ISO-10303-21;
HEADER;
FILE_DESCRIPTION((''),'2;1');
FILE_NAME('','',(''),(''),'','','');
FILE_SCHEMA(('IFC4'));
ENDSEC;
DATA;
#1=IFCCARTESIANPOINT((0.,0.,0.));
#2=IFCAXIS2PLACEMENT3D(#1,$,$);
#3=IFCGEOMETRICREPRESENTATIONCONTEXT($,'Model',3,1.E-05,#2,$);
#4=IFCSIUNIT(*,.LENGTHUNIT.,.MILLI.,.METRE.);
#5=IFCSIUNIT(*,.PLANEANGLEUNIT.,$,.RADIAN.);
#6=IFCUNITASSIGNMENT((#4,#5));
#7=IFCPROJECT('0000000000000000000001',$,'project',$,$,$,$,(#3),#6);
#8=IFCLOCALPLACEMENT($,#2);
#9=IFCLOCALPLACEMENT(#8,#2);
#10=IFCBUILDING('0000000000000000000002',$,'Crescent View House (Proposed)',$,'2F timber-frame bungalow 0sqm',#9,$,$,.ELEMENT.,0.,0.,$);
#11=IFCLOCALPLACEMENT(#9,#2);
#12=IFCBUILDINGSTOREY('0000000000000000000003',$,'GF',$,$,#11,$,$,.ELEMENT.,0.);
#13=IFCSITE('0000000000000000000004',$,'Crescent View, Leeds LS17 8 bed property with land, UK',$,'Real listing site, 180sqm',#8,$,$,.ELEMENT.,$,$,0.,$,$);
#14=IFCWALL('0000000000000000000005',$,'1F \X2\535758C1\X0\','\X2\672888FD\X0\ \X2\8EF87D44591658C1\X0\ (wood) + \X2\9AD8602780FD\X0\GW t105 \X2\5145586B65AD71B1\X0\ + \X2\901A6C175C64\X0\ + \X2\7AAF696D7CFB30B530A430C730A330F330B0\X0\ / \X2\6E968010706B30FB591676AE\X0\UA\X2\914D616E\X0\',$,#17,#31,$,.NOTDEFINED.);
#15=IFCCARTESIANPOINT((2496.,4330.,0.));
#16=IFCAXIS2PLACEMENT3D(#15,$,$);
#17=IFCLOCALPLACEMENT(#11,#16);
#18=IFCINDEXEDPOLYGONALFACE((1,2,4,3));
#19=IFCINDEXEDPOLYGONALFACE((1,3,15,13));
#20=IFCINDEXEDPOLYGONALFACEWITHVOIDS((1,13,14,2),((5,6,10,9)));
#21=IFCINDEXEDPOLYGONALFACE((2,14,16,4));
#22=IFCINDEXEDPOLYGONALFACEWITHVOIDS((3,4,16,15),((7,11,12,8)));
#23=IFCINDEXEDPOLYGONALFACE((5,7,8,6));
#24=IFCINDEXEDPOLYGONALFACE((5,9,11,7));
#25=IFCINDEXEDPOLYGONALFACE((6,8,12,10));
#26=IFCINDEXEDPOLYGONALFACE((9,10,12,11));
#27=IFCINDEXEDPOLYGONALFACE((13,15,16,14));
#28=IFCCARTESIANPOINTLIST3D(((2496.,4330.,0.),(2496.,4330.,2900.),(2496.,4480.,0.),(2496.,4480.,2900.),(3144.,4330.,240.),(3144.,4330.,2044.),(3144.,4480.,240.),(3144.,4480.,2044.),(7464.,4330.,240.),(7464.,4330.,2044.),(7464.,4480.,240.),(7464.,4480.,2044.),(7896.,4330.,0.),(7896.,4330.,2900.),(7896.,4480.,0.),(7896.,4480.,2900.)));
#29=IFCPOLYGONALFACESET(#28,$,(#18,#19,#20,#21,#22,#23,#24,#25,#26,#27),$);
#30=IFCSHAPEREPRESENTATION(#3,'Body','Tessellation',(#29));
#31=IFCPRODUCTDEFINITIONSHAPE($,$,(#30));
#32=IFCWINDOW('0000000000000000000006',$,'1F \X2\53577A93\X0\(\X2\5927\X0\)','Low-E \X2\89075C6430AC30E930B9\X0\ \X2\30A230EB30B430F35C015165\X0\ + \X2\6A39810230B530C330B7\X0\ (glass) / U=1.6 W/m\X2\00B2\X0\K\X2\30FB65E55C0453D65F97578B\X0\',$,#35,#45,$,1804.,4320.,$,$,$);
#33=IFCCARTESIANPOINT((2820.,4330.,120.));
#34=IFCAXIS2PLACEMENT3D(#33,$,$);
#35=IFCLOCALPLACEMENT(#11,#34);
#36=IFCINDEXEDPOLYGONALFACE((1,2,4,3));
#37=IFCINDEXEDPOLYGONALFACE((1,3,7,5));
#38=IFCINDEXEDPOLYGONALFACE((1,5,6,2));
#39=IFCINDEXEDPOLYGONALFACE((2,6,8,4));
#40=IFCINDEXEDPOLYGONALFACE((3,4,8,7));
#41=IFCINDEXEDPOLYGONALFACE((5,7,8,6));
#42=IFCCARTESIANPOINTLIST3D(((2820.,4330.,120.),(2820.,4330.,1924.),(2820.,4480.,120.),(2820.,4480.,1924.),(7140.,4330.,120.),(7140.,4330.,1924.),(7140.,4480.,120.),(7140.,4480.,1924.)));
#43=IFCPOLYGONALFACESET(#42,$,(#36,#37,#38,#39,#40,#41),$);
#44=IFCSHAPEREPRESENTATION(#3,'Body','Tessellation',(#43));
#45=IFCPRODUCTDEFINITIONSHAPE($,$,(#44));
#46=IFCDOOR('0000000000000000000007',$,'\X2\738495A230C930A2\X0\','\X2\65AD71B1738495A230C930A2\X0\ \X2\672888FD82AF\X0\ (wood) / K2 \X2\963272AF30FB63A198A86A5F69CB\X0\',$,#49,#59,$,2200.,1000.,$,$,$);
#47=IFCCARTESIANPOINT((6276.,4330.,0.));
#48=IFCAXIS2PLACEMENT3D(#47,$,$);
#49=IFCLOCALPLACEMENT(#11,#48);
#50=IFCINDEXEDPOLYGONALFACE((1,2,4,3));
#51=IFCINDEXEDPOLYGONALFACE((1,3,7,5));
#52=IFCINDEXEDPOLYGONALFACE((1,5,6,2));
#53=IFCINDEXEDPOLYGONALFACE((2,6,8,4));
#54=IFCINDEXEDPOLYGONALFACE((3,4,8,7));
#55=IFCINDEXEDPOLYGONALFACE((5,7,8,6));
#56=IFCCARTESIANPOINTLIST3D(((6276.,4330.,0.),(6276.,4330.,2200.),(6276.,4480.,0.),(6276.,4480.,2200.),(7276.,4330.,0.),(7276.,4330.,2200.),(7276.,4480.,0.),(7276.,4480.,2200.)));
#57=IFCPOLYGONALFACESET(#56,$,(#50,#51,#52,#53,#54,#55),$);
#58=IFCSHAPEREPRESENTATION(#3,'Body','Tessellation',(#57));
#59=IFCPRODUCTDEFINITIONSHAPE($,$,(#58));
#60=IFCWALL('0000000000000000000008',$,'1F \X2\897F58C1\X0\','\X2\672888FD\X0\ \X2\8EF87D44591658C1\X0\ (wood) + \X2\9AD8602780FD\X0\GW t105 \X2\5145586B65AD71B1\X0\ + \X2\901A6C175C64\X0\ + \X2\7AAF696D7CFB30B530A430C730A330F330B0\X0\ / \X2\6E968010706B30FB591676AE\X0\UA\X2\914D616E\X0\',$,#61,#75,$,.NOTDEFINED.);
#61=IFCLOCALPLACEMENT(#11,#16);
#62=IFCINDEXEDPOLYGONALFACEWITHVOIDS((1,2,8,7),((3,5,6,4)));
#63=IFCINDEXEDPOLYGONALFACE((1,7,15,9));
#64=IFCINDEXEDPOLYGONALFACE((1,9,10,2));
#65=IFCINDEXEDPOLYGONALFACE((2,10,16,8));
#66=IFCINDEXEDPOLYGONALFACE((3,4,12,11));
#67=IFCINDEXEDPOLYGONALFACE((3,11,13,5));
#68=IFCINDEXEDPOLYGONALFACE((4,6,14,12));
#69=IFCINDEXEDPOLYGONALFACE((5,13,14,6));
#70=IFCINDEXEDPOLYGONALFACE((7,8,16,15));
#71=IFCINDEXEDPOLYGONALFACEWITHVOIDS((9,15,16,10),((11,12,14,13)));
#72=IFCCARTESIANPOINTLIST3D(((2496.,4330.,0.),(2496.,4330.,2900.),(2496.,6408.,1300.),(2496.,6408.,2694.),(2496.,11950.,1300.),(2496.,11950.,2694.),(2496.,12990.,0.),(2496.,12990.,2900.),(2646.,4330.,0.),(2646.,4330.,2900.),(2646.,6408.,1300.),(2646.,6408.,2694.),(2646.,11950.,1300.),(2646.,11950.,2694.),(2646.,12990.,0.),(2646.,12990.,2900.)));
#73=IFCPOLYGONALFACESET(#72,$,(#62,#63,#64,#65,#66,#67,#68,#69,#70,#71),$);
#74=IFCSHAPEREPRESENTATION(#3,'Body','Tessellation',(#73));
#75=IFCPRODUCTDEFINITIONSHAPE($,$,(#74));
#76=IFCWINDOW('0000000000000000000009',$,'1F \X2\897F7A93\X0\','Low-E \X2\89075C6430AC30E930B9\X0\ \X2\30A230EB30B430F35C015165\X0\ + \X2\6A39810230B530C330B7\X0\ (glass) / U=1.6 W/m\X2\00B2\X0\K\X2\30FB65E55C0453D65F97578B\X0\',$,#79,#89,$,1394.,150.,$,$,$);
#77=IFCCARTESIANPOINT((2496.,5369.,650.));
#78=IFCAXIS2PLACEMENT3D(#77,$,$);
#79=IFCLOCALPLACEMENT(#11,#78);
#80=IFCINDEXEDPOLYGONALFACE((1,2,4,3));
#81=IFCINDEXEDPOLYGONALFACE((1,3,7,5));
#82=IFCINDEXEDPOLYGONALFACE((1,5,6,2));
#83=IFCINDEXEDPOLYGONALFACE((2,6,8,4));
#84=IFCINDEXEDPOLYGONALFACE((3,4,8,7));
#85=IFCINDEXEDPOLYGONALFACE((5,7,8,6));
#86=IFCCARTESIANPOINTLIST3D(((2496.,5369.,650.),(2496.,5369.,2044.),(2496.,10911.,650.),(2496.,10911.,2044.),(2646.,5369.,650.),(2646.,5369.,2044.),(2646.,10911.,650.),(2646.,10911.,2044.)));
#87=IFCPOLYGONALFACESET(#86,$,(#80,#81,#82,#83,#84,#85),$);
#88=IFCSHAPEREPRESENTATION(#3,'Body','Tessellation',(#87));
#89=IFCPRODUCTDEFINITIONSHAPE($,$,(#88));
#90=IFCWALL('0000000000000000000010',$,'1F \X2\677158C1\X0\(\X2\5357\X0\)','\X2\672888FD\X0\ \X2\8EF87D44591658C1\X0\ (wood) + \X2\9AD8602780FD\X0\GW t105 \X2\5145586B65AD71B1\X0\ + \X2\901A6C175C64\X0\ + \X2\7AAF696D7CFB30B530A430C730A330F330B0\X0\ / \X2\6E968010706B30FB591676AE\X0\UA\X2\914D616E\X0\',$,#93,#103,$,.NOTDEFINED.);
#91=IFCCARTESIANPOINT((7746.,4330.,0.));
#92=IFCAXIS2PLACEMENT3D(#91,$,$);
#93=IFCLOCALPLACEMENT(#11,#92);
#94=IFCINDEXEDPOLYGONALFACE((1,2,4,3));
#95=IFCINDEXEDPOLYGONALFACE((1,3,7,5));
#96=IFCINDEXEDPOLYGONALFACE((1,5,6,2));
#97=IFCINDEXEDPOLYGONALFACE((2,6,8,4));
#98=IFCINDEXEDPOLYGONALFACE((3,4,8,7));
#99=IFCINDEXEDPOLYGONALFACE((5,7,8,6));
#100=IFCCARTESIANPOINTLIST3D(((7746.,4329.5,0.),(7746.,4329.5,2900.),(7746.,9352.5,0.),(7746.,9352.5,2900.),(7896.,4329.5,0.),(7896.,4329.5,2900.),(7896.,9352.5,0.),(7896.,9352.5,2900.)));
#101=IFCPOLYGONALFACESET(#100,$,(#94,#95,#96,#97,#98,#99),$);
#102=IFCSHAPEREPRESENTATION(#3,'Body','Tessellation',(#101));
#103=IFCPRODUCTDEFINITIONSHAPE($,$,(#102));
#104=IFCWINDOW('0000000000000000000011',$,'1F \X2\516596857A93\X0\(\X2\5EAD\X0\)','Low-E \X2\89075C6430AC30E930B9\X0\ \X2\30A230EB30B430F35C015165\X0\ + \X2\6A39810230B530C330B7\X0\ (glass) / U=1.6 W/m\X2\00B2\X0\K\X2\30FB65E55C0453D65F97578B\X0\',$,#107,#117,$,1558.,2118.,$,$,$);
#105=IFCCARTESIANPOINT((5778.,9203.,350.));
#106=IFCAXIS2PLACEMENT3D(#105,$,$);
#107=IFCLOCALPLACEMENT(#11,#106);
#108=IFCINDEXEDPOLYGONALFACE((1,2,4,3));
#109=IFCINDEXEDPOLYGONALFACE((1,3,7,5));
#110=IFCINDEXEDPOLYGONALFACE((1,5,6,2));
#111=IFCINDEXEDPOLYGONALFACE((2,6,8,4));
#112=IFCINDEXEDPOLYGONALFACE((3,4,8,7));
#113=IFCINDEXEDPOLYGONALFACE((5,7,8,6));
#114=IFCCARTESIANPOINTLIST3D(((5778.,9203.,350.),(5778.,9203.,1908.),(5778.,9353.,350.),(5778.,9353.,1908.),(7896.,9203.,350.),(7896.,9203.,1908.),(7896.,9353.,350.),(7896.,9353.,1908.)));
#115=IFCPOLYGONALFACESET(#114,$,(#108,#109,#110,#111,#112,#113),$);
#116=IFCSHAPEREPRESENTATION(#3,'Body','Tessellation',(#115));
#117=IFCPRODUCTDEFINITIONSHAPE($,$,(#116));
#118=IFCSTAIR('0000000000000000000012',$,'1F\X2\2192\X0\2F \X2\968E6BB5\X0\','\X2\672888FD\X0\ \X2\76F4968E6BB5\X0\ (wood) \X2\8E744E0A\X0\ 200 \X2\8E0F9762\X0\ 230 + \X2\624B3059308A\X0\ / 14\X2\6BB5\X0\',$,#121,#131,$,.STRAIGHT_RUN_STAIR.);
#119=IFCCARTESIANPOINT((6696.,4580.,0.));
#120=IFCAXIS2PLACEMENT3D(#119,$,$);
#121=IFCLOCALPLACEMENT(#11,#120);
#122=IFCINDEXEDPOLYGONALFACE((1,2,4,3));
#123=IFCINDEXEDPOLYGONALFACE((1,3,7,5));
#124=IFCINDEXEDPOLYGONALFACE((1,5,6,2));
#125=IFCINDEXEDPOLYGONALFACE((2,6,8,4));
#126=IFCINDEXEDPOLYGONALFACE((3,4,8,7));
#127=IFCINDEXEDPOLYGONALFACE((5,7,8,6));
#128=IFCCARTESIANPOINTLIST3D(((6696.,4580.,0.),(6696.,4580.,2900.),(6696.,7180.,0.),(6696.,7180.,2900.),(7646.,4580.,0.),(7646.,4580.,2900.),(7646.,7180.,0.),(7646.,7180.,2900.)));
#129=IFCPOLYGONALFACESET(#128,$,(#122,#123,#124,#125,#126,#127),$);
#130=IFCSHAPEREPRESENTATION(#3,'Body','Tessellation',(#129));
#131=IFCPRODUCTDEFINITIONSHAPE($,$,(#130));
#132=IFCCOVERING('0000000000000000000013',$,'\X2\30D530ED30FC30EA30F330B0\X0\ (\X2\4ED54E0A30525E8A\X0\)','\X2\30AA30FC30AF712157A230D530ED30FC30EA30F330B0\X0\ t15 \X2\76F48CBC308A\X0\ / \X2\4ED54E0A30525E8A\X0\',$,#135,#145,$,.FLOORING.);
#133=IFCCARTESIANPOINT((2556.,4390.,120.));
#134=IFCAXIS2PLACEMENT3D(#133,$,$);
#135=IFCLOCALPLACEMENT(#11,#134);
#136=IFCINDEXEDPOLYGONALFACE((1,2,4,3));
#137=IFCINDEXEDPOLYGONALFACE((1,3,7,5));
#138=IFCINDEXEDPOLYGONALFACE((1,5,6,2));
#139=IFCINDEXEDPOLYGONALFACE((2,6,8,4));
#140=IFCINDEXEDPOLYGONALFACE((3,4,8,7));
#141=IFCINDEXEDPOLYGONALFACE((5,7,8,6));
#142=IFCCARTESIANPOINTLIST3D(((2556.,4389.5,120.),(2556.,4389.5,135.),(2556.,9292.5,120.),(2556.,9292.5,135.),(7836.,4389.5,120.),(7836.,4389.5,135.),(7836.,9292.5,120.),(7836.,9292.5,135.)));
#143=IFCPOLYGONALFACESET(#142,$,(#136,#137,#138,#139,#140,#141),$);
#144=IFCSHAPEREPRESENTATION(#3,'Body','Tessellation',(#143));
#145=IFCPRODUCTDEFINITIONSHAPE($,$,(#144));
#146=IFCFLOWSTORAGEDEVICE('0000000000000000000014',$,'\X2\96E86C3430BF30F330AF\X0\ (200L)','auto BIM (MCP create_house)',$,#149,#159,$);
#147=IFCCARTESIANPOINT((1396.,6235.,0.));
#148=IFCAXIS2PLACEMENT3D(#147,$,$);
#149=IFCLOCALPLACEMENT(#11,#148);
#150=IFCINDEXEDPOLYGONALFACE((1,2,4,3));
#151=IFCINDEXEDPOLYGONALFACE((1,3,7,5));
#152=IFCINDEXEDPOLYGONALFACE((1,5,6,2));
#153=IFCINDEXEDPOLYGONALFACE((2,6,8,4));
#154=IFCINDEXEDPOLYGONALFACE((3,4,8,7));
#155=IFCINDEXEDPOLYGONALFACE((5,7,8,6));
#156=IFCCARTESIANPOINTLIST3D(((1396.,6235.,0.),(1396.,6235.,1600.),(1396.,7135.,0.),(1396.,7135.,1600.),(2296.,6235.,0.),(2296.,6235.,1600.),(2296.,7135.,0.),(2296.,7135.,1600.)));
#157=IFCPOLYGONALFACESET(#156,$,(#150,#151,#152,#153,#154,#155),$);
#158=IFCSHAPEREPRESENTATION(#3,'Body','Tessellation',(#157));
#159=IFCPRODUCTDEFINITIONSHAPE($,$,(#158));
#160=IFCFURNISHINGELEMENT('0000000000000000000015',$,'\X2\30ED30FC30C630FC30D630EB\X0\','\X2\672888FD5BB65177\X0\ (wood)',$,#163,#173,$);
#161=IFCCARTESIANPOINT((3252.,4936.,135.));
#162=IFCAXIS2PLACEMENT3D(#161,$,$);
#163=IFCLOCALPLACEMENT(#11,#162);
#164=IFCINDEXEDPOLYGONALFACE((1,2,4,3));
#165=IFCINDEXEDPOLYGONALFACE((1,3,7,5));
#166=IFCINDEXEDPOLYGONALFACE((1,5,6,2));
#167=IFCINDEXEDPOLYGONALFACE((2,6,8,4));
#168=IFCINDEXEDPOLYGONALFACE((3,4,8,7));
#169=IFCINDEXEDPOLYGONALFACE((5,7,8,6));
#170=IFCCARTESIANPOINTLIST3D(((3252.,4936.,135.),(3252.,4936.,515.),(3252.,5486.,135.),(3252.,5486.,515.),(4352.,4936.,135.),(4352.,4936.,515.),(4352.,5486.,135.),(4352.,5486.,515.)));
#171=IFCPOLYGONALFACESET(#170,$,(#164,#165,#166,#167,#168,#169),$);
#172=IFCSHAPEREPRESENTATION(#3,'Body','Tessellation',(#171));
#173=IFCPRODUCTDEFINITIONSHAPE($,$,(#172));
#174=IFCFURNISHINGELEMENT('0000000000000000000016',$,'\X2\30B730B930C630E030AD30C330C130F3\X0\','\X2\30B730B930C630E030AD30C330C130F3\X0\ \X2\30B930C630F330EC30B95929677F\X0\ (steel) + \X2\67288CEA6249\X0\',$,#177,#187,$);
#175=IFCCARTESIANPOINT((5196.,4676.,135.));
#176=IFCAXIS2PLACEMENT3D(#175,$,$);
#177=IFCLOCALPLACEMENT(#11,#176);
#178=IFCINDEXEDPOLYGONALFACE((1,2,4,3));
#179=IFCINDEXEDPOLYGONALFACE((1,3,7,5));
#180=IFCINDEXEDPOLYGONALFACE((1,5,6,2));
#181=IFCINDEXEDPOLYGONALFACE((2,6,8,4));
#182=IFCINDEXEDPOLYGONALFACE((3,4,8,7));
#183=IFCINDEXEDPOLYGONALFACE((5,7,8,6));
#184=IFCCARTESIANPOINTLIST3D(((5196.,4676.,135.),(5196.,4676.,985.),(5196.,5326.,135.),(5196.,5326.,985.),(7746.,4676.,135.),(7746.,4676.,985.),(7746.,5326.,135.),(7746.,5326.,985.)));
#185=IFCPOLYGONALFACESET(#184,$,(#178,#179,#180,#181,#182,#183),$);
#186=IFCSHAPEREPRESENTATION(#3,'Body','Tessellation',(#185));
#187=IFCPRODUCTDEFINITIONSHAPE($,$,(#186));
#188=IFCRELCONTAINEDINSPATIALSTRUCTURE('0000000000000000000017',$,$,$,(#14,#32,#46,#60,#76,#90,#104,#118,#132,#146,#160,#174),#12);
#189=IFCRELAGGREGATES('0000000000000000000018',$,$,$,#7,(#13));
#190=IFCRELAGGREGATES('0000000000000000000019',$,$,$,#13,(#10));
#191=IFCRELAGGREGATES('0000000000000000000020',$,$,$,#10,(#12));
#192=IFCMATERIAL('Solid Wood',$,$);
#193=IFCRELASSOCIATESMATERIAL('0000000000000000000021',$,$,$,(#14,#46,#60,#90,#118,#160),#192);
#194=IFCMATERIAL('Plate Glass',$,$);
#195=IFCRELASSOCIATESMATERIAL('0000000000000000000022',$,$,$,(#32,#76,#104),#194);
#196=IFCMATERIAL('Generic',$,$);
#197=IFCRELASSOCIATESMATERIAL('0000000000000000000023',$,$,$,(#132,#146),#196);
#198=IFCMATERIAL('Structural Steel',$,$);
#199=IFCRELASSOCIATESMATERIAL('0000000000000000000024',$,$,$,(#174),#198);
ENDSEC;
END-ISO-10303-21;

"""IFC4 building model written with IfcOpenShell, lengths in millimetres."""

from ifc_helpers import new_model, si_unit, frame, frame_2d, origin, place, context, project, spatial, rectangle, extrude, material, element, fill, save


model = new_model("IFC4")

# Units and contexts
model_context = context("Model", 3, precision=1e-05, world=origin())
ifc_project = project(units=[si_unit("LENGTHUNIT", "METRE", prefix="MILLI"), si_unit("PLANEANGLEUNIT", "RADIAN")], contexts=[model_context])

# Site, building, storey
site_placement = place(None, origin())
site = spatial("IfcSite", under=ifc_project, at=site_placement, Name="Crescent View, Leeds LS17 8 bed property with land, UK", ObjectType="Real listing site, 180sqm", CompositionType="ELEMENT", RefElevation=0.0)
building_placement = place(site_placement, origin())
building = spatial("IfcBuilding", under=site, at=building_placement, Name="Crescent View House (Proposed)", ObjectType="2F timber-frame bungalow 0sqm", CompositionType="ELEMENT", ElevationOfRefHeight=0.0, ElevationOfTerrain=0.0)
storey_placement = place(building_placement, origin())
storey = spatial("IfcBuildingStorey", under=building, at=storey_placement, Name="GF", CompositionType="ELEMENT", Elevation=0.0)

# Shared definitions
ifc_material_1 = material(Name="Solid Wood")

# Wall, openings, window, door
wall_1_placement = place(storey_placement, frame((2496.0, 4330.0, 0.0)))
wall_1 = element("IfcWall", 1, at=wall_1_placement, inside=storey, material=ifc_material_1, Name="1F 南壁", Description="木製 軸組外壁 (wood) + 高性能GW t105 充填断熱 + 通気層 + 窯業系サイディング / 準耐火・外皮UA配慮", PredefinedType="NOTDEFINED", context=model_context, shape_type="SweptSolid", body=[
    extrude(rectangle(XDim=5400.0, YDim=150.0, at=frame_2d((2700.0, 75.0))), frame((2496.0, 4330.0, 0.0)), (0.0, 0.0, 1.0), 2900.0),
])
opening_1_placement = place(storey_placement, frame((2820.0, 4330.0, 120.0)))
opening_1 = element("IfcOpeningElement", 2, at=opening_1_placement, cuts=wall_1, PredefinedType="NOTDEFINED", context=model_context, shape_type="SweptSolid", body=[
    extrude(rectangle(XDim=4320.0, YDim=150.0, at=frame_2d((2160.0, 75.0))), frame((2820.0, 4330.0, 120.0)), (0.0, 0.0, 1.0), 1804.0),
])
opening_2_placement = place(storey_placement, frame((6276.0, 4330.0, 0.0)))
opening_2 = element("IfcOpeningElement", 3, at=opening_2_placement, cuts=wall_1, PredefinedType="NOTDEFINED", context=model_context, shape_type="SweptSolid", body=[
    extrude(rectangle(XDim=1000.0, YDim=150.0, at=frame_2d((500.0, 75.0))), frame((6276.0, 4330.0, 0.0)), (0.0, 0.0, 1.0), 2200.0),
])
ifc_material_2 = material(Name="Plate Glass")
window_1_placement = place(storey_placement, frame((2820.0, 4330.0, 120.0)))
window_1 = element("IfcWindow", 4, at=window_1_placement, inside=storey, material=ifc_material_2, Name="1F 南窓(大)", Description="Low-E 複層ガラス アルゴン封入 + 樹脂サッシ (glass) / U=1.6 W/m²K・日射取得型", OverallHeight=1804.0, OverallWidth=4320.0, context=model_context, shape_type="SweptSolid", body=[
    extrude(rectangle(XDim=4320.0, YDim=150.0, at=frame_2d((2160.0, 75.0))), frame((2820.0, 4330.0, 120.0)), (0.0, 0.0, 1.0), 1804.0),
])
fill(opening_1, window_1)
door_1_placement = place(storey_placement, frame((6276.0, 4330.0, 0.0)))
door_1 = element("IfcDoor", 5, at=door_1_placement, inside=storey, material=ifc_material_1, Name="玄関ドア", Description="断熱玄関ドア 木製芯 (wood) / K2 防犯・採風機構", OverallHeight=2200.0, OverallWidth=1000.0, context=model_context, shape_type="SweptSolid", body=[
    extrude(rectangle(XDim=1000.0, YDim=150.0, at=frame_2d((500.0, 75.0))), frame((6276.0, 4330.0, 0.0)), (0.0, 0.0, 1.0), 2200.0),
])
fill(opening_2, door_1)

# Walls, openings, windows
wall_2_placement = place(storey_placement, frame((2496.0, 4330.0, 0.0)))
wall_2 = element("IfcWall", 6, at=wall_2_placement, inside=storey, material=ifc_material_1, Name="1F 西壁", Description="木製 軸組外壁 (wood) + 高性能GW t105 充填断熱 + 通気層 + 窯業系サイディング / 準耐火・外皮UA配慮", PredefinedType="NOTDEFINED", context=model_context, shape_type="SweptSolid", body=[
    extrude(rectangle(XDim=150.0, YDim=8660.0, at=frame_2d((75.0, 4330.0))), frame((2496.0, 4330.0, 0.0)), (0.0, 0.0, 1.0), 2900.0),
])
opening_3_placement = place(storey_placement, frame((2496.0, 5369.0, 650.0)))
opening_3 = element("IfcOpeningElement", 7, at=opening_3_placement, cuts=wall_2, PredefinedType="NOTDEFINED", context=model_context, shape_type="SweptSolid", body=[
    extrude(rectangle(XDim=150.0, YDim=5542.0, at=frame_2d((75.0, 2771.0))), frame((2496.0, 5369.0, 650.0)), (0.0, 0.0, 1.0), 1394.0),
])
window_2_placement = place(storey_placement, frame((2496.0, 5369.0, 650.0)))
window_2 = element("IfcWindow", 8, at=window_2_placement, inside=storey, material=ifc_material_2, Name="1F 西窓", Description="Low-E 複層ガラス アルゴン封入 + 樹脂サッシ (glass) / U=1.6 W/m²K・日射取得型", OverallHeight=1394.0, OverallWidth=150.0, context=model_context, shape_type="SweptSolid", body=[
    extrude(rectangle(XDim=150.0, YDim=5542.0, at=frame_2d((75.0, 2771.0))), frame((2496.0, 5369.0, 650.0)), (0.0, 0.0, 1.0), 1394.0),
])
fill(opening_3, window_2)
wall_3_placement = place(storey_placement, frame((7746.0, 4330.0, 0.0)))
wall_3 = element("IfcWall", 9, at=wall_3_placement, inside=storey, material=ifc_material_1, Name="1F 東壁(南)", Description="木製 軸組外壁 (wood) + 高性能GW t105 充填断熱 + 通気層 + 窯業系サイディング / 準耐火・外皮UA配慮", PredefinedType="NOTDEFINED", context=model_context, shape_type="SweptSolid", body=[
    extrude(rectangle(XDim=150.0, YDim=5023.0, at=frame_2d((75.0, 2511.0))), frame((7746.0, 4330.0, 0.0)), (0.0, 0.0, 1.0), 2900.0),
])
opening_4_placement = place(storey_placement, frame((5778.0, 9203.0, 350.0)))
opening_4 = element("IfcOpeningElement", 10, at=opening_4_placement, cuts=wall_3, PredefinedType="NOTDEFINED", context=model_context, shape_type="SweptSolid", body=[
    extrude(rectangle(XDim=2118.0, YDim=150.0, at=frame_2d((1059.0, 75.0))), frame((5778.0, 9203.0, 350.0)), (0.0, 0.0, 1.0), 1558.0),
])
window_3_placement = place(storey_placement, frame((5778.0, 9203.0, 350.0)))
window_3 = element("IfcWindow", 11, at=window_3_placement, inside=storey, material=ifc_material_2, Name="1F 入隅窓(庭)", Description="Low-E 複層ガラス アルゴン封入 + 樹脂サッシ (glass) / U=1.6 W/m²K・日射取得型", OverallHeight=1558.0, OverallWidth=2118.0, context=model_context, shape_type="SweptSolid", body=[
    extrude(rectangle(XDim=2118.0, YDim=150.0, at=frame_2d((1059.0, 75.0))), frame((5778.0, 9203.0, 350.0)), (0.0, 0.0, 1.0), 1558.0),
])
fill(opening_4, window_3)

# Stair
stair_placement = place(storey_placement, frame((6696.0, 4580.0, 0.0)))
element("IfcStair", 12, at=stair_placement, inside=storey, material=ifc_material_1, Name="1F→2F 階段", Description="木製 直階段 (wood) 蹴上 200 踏面 230 + 手すり / 14段", PredefinedType="STRAIGHT_RUN_STAIR", context=model_context, shape_type="SweptSolid", body=[
    extrude(rectangle(XDim=950.0, YDim=2600.0, at=frame_2d((475.0, 1300.0))), frame((6696.0, 4580.0, 0.0)), (0.0, 0.0, 1.0), 2900.0),
])

# Covering
ifc_material_3 = material(Name="Generic")
covering_placement = place(storey_placement, frame((2556.0, 4390.0, 120.0)))
element("IfcCovering", 13, at=covering_placement, inside=storey, material=ifc_material_3, Name="フローリング (仕上げ床)", Description="オーク無垢フローリング t15 直貼り / 仕上げ床", PredefinedType="FLOORING", context=model_context, shape_type="SweptSolid", body=[
    extrude(rectangle(XDim=5280.0, YDim=4903.0, at=frame_2d((2640.0, 2451.0))), frame((2556.0, 4390.0, 120.0)), (0.0, 0.0, 1.0), 15.0),
])

# Flow storage device
flow_storage_device_placement = place(storey_placement, frame((1396.0, 6235.0, 0.0)))
element("IfcFlowStorageDevice", 14, at=flow_storage_device_placement, inside=storey, material=ifc_material_3, Name="雨水タンク (200L)", Description="auto BIM (MCP create_house)", context=model_context, shape_type="SweptSolid", body=[
    extrude(rectangle(XDim=900.0, YDim=900.0, at=frame_2d((450.0, 450.0))), frame((1396.0, 6235.0, 0.0)), (0.0, 0.0, 1.0), 1600.0),
])

# Furnishing elements
furnishing_1_placement = place(storey_placement, frame((3252.0, 4936.0, 135.0)))
element("IfcFurnishingElement", 15, at=furnishing_1_placement, inside=storey, material=ifc_material_1, Name="ローテーブル", Description="木製家具 (wood)", context=model_context, shape_type="SweptSolid", body=[
    extrude(rectangle(XDim=1100.0, YDim=550.0, at=frame_2d((550.0, 275.0))), frame((3252.0, 4936.0, 135.0)), (0.0, 0.0, 1.0), 380.0),
])
ifc_material_4 = material(Name="Structural Steel")
furnishing_2_placement = place(storey_placement, frame((5196.0, 4676.0, 135.0)))
element("IfcFurnishingElement", 16, at=furnishing_2_placement, inside=storey, material=ifc_material_4, Name="システムキッチン", Description="システムキッチン ステンレス天板 (steel) + 木質扉", context=model_context, shape_type="SweptSolid", body=[
    extrude(rectangle(XDim=2550.0, YDim=650.0, at=frame_2d((1275.0, 325.0))), frame((5196.0, 4676.0, 135.0)), (0.0, 0.0, 1.0), 850.0),
])

save(model, "model.ifc")
